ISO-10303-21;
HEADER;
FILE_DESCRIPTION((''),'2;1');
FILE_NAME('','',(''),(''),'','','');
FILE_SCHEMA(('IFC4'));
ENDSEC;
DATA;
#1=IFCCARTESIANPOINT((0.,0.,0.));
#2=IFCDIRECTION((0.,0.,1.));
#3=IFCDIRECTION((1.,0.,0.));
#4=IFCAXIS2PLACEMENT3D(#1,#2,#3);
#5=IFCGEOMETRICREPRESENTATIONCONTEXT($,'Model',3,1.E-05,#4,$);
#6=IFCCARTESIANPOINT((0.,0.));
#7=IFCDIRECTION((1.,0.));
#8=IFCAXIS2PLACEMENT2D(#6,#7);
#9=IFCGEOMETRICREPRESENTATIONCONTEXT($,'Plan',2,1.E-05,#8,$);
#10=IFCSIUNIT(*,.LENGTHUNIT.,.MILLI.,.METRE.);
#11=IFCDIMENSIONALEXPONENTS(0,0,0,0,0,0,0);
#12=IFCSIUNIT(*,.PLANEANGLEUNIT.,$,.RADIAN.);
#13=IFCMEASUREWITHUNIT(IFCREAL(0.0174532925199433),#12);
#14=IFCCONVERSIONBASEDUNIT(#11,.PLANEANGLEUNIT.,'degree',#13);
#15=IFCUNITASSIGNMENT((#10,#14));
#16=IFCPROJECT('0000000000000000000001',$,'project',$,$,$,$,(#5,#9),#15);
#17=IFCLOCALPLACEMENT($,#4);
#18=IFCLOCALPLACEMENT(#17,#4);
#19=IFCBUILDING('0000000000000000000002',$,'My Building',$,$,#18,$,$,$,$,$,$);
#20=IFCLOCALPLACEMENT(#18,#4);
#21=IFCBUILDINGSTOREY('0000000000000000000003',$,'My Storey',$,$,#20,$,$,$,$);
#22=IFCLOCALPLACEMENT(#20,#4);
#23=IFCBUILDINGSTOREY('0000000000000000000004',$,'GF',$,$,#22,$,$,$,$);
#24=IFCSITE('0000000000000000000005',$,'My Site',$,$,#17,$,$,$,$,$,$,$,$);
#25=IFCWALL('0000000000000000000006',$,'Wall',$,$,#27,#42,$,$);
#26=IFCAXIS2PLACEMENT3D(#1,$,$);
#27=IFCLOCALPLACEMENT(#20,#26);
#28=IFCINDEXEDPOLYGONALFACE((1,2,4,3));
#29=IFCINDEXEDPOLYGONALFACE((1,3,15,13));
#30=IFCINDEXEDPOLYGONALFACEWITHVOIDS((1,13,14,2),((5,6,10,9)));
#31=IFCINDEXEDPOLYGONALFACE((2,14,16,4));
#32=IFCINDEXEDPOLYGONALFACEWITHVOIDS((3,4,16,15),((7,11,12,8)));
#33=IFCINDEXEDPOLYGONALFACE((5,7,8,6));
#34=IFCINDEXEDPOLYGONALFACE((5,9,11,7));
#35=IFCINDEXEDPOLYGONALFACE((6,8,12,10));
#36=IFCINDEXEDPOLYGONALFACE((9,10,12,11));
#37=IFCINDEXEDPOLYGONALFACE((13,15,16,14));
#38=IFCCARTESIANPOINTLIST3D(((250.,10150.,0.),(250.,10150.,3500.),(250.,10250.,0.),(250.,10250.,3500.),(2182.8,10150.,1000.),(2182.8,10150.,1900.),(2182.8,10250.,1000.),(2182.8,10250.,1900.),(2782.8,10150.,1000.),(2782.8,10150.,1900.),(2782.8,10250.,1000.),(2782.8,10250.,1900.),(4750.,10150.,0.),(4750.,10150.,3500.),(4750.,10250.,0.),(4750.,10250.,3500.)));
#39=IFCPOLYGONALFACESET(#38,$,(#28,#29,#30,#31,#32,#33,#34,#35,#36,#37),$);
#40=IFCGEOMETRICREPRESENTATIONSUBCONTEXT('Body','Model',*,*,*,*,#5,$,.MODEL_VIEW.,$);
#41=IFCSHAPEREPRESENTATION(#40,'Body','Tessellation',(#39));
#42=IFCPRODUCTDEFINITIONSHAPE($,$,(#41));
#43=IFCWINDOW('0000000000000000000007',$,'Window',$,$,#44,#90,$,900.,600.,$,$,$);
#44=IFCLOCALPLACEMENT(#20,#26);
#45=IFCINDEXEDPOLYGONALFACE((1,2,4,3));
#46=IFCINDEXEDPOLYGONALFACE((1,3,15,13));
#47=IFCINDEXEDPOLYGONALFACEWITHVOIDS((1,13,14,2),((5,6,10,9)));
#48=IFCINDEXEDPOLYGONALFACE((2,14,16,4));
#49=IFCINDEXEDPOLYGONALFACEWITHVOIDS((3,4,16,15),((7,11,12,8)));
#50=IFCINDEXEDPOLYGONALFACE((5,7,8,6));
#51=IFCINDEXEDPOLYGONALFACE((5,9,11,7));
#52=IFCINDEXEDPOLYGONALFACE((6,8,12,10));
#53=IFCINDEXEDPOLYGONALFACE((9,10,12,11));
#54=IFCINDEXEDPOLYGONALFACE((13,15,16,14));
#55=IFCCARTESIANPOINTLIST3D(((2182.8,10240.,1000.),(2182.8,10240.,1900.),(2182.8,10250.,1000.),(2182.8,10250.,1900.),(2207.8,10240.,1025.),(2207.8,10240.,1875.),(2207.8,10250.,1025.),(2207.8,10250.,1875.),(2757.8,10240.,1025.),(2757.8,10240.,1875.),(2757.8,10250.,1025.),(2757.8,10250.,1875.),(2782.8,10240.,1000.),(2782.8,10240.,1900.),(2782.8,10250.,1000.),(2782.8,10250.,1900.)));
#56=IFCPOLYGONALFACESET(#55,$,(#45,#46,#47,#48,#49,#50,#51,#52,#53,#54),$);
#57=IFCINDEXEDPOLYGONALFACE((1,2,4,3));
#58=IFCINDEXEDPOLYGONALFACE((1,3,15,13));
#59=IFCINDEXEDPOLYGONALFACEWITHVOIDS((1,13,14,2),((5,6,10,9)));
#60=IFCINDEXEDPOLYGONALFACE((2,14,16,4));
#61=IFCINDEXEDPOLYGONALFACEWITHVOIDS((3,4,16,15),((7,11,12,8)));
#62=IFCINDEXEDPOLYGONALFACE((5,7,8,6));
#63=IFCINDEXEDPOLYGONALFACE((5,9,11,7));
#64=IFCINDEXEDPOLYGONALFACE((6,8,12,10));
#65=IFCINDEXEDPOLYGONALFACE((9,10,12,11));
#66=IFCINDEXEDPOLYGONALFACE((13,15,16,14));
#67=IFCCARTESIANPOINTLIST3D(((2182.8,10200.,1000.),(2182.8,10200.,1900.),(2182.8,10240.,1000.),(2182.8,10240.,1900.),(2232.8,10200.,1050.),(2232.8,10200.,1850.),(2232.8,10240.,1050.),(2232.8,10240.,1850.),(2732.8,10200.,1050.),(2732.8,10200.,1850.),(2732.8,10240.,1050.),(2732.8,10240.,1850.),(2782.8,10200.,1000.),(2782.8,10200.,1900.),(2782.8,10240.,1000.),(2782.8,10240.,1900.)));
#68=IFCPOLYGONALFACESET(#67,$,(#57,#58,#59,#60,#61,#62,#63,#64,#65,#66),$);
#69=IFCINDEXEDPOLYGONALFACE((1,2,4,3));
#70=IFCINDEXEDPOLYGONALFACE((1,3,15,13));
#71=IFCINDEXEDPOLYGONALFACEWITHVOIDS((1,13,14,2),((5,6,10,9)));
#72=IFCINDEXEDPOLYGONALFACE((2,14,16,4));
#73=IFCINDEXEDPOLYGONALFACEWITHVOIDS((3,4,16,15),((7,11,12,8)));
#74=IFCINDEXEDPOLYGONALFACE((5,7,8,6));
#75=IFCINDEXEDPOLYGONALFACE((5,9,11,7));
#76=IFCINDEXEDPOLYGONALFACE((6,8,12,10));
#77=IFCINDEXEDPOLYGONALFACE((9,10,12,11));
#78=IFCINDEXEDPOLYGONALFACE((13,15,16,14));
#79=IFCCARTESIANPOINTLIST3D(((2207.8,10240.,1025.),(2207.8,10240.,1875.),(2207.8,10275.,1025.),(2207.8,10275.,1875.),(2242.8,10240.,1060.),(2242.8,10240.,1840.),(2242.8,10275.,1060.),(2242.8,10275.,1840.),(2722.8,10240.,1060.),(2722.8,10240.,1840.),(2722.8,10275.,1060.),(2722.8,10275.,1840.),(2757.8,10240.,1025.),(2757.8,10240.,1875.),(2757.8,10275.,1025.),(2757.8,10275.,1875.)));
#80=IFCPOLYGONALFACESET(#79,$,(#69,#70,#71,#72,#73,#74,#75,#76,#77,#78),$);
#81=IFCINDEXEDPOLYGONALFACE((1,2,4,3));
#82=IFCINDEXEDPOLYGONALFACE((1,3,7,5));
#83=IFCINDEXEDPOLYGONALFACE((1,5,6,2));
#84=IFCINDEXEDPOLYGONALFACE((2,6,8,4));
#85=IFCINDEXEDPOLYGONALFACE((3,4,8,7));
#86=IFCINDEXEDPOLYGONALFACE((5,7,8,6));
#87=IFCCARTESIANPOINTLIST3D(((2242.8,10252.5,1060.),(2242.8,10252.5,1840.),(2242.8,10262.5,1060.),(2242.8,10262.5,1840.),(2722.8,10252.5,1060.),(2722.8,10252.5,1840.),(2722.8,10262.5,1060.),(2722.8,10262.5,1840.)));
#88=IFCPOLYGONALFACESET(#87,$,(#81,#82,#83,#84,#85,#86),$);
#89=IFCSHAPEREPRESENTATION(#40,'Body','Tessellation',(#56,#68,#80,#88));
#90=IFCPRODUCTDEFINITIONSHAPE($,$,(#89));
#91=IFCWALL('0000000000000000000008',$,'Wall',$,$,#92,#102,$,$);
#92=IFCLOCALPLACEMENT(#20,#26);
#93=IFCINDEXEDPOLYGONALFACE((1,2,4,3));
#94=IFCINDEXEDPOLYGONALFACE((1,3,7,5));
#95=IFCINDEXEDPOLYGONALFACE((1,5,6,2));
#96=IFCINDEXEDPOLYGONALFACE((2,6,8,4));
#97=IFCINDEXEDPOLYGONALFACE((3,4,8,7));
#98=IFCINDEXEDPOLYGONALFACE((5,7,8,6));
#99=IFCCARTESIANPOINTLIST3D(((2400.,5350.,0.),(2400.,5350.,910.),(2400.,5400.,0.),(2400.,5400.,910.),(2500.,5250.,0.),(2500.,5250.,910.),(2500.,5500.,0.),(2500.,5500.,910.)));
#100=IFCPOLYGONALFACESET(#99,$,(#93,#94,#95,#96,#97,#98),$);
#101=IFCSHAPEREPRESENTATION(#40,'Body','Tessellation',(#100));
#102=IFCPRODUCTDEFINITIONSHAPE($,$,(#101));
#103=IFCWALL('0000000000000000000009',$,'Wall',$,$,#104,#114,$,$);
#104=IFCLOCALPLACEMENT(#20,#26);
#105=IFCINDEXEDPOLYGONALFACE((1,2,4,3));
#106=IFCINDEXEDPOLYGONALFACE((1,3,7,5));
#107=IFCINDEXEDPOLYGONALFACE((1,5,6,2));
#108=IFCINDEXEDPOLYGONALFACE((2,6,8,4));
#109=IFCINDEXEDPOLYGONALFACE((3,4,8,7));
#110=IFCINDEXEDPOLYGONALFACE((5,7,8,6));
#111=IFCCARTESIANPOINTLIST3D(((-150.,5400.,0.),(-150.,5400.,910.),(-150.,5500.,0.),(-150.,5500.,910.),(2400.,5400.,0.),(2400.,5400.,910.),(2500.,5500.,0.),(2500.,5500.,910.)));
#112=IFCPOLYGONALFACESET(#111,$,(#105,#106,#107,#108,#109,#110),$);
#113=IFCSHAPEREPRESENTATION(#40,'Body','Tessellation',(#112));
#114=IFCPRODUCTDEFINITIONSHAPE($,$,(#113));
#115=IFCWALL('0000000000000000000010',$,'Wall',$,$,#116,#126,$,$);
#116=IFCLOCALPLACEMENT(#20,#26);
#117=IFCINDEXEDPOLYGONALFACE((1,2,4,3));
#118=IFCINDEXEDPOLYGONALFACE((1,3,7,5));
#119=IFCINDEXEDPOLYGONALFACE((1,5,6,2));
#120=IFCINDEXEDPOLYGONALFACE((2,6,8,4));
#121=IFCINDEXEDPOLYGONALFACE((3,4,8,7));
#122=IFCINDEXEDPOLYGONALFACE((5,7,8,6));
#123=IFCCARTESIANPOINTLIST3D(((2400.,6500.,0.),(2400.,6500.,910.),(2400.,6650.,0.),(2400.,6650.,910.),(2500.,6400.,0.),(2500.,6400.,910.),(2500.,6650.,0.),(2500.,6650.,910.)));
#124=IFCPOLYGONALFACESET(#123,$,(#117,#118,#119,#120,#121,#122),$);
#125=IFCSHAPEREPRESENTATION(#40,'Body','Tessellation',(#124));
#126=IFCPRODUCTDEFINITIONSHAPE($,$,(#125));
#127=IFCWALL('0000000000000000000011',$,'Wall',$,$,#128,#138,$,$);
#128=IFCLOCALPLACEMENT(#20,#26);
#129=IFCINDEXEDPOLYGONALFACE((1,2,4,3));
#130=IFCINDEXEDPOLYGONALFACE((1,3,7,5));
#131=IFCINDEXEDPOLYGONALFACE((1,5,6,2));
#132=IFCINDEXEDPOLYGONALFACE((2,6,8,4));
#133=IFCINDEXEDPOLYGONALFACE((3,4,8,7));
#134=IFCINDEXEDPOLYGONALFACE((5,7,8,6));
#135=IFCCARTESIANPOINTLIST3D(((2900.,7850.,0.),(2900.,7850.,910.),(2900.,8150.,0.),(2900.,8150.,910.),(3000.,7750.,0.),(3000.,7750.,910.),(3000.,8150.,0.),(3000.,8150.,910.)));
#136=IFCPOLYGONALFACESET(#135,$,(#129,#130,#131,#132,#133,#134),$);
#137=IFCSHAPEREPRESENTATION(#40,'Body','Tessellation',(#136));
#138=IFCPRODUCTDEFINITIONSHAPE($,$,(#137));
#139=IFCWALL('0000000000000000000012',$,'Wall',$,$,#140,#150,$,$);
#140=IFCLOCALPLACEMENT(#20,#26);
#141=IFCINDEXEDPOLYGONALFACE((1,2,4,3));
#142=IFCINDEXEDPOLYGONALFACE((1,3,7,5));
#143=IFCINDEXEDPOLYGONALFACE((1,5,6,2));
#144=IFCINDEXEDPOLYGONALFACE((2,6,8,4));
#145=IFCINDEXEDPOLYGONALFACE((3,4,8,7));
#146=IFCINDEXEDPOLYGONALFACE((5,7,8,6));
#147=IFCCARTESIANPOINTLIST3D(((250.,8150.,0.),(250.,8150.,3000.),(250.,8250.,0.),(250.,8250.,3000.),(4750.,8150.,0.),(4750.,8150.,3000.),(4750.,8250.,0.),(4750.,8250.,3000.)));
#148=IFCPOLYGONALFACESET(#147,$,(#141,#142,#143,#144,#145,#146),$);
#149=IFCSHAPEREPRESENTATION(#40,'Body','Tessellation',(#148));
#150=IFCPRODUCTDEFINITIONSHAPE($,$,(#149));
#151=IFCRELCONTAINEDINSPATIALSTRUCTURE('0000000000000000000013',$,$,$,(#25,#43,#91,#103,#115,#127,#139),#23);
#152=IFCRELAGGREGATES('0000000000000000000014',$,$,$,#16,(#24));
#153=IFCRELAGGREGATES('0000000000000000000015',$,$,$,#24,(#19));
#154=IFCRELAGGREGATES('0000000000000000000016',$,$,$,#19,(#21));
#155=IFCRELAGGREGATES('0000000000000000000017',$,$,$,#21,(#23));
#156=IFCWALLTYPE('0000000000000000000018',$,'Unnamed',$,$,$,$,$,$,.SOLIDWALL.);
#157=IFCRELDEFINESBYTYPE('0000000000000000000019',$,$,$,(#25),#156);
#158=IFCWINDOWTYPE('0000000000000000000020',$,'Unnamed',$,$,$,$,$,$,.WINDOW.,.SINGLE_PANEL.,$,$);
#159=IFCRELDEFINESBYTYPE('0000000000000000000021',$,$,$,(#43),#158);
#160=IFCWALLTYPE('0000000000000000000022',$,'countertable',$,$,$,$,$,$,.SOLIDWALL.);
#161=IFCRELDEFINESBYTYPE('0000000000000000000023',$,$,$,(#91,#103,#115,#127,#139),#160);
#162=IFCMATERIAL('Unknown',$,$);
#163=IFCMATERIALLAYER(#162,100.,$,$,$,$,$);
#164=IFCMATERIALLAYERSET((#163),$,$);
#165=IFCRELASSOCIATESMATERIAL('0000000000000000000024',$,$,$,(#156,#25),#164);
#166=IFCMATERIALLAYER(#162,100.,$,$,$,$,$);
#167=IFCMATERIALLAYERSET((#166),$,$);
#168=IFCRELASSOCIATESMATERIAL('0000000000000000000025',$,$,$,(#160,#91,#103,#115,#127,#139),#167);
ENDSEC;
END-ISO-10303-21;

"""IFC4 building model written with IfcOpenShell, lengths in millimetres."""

from ifc_helpers import new_model, entity, si_unit, converted_unit, frame, origin_with_axes, origin_2d_with_axis, place, context, subcontext, project, spatial, line, indexed_curve, outline, extrude, shape, source, transform, mapped, material, layer, layer_set, layer_usage, type_object, type_shapes, element, fill, save


model = new_model("IFC4")

# Units and contexts
model_context = context("Model", 3, precision=1e-05, world=origin_with_axes())
plan_context = context("Plan", 2, precision=1e-05, world=origin_2d_with_axis())
body_context_1 = subcontext(model_context, "Body", "Model", "MODEL_VIEW")
body_context_2 = subcontext(plan_context, "Body", "Plan", "PLAN_VIEW")
ifc_project = project(units=[si_unit("LENGTHUNIT", "METRE", prefix="MILLI"), converted_unit("PLANEANGLEUNIT", "degree", entity("IfcReal", 0.0174532925199433), si_unit("PLANEANGLEUNIT", "RADIAN"), dimensions=[0, 0, 0, 0, 0, 0, 0])], contexts=[model_context, plan_context])

# Site, building, storeys
site_placement = place(None, origin_with_axes())
site = spatial("IfcSite", under=ifc_project, at=site_placement, Name="My Site")
building_placement = place(site_placement, origin_with_axes())
building = spatial("IfcBuilding", under=site, at=building_placement, Name="My Building")
storey_1_placement = place(building_placement, origin_with_axes())
storey_1 = spatial("IfcBuildingStorey", under=building, at=storey_1_placement, Name="My Storey")
storey_2_placement = place(storey_1_placement, origin_with_axes())
storey_2 = spatial("IfcBuildingStorey", under=storey_1, at=storey_2_placement, Name="GF")

# Shared definitions
ifc_material = material(Name="Unknown")
ifc_layer_1 = layer(ifc_material, 100.0)
ifc_layer_set_1 = layer_set([ifc_layer_1])
wall_type_1 = type_object("IfcWallType", Name="Unnamed", PredefinedType="SOLIDWALL", material=ifc_layer_set_1)

# Shared definitions
shared_shape_1 = source(origin_with_axes(), body_context_1, "Body", "SweptSolid", [
    extrude(outline(indexed_curve([(0.0, 0.0), (600.0, 0.0), (600.0, 900.0), (0.0, 900.0)], segments=[line(1, 2, 3, 4, 1)])), frame((0.0, -600.0, 0.0), z_axis=(0.0, -1.0, 0.0), x_axis=(1.0, 0.0, 0.0)), (0.0, 0.0, -1.0), 1200.0),
])
window_type = type_object("IfcWindowType", Name="Unnamed", PartitioningType="SINGLE_PANEL", PredefinedType="WINDOW")
shared_shape_2 = source(origin_with_axes(), body_context_1, "Body", "SweptSolid", [
    extrude(outline(indexed_curve([(0.0, 0.0), (600.0, 0.0), (600.0, 900.0), (0.0, 900.0)], segments=[line(1, 2, 3, 4, 1)]), holes=[indexed_curve([(25.0, 25.0), (575.0, 25.0), (575.0, 875.0), (25.0, 875.0)], segments=[line(1, 2, 3, 4, 1)])]), frame((0.0, 90.0, 0.0), z_axis=(0.0, -1.0, 0.0), x_axis=(1.0, 0.0, 0.0)), (0.0, 0.0, -1.0), 10.0),
    extrude(outline(indexed_curve([(0.0, 0.0), (600.0, 0.0), (600.0, 900.0), (0.0, 900.0)], segments=[line(1, 2, 3, 4, 1)]), holes=[indexed_curve([(50.0, 50.0), (550.0, 50.0), (550.0, 850.0), (50.0, 850.0)], segments=[line(1, 2, 3, 4, 1)])]), frame((0.0, 50.0, 0.0), z_axis=(0.0, -1.0, 0.0), x_axis=(1.0, 0.0, 0.0)), (0.0, 0.0, -1.0), 40.0),
    extrude(outline(indexed_curve([(0.0, 0.0), (550.0, 0.0), (550.0, 850.0), (0.0, 850.0)], segments=[line(1, 2, 3, 4, 1)]), holes=[indexed_curve([(35.0, 35.0), (515.0, 35.0), (515.0, 815.0), (35.0, 815.0)], segments=[line(1, 2, 3, 4, 1)])]), frame((25.0, 90.0, 25.0), z_axis=(0.0, -1.0, 0.0), x_axis=(1.0, 0.0, 0.0)), (0.0, 0.0, -1.0), 35.0),
    extrude(outline(indexed_curve([(35.0, 35.0), (515.0, 35.0), (515.0, 815.0), (35.0, 815.0)], segments=[line(1, 2, 3, 4, 1)])), frame((25.0, 102.5, 25.0), z_axis=(0.0, -1.0, 0.0), x_axis=(1.0, 0.0, 0.0)), (0.0, 0.0, -1.0), 10.0),
])
shared_shape_3 = source(origin_with_axes(), body_context_2, "Body", "Curve2D", [
    entity("IfcIndexedPolyCurve", entity("IfcCartesianPointList2D", [[50.0, 50.0], [550.0, 50.0]])),
    entity("IfcIndexedPolyCurve", entity("IfcCartesianPointList2D", [[0.0, 100.0], [25.0, 100.0], [25.0, 90.0], [50.0, 90.0], [50.0, 50.0], [0.0, 50.0]]), [entity("IfcLineIndex", [1, 2, 3, 4, 5, 6, 1])]),
    entity("IfcIndexedPolyCurve", entity("IfcCartesianPointList2D", [[600.0, 100.0], [575.0, 100.0], [575.0, 90.0], [550.0, 90.0], [550.0, 50.0], [600.0, 50.0]]), [entity("IfcLineIndex", [1, 2, 3, 4, 5, 6, 1])]),
    entity("IfcIndexedPolyCurve", entity("IfcCartesianPointList2D", [[25.0, 90.0], [60.0, 90.0], [60.0, 125.0], [25.0, 125.0]]), [entity("IfcLineIndex", [1, 2, 3, 4, 1])]),
    entity("IfcIndexedPolyCurve", entity("IfcCartesianPointList2D", [[575.0, 90.0], [540.0, 90.0], [540.0, 125.0], [575.0, 125.0]]), [entity("IfcLineIndex", [1, 2, 3, 4, 1])]),
    entity("IfcIndexedPolyCurve", entity("IfcCartesianPointList2D", [[60.0, 90.0], [540.0, 90.0]])),
    entity("IfcIndexedPolyCurve", entity("IfcCartesianPointList2D", [[60.0, 125.0], [540.0, 125.0]])),
    entity("IfcIndexedPolyCurve", entity("IfcCartesianPointList2D", [[60.0, 107.5], [540.0, 107.5]])),
])
type_shapes(window_type, [shared_shape_2, shared_shape_3])

# Wall, opening, window
ifc_layer_usage_1 = layer_usage(ifc_layer_set_1, "AXIS2", "POSITIVE", 0.0)
wall_1_placement = place(storey_2_placement, frame((250.0, 10150.0, 0.0), z_axis=(0.0, 0.0, 1.0), x_axis=(1.0, 0.0, 0.0)))
wall_1 = element("IfcWall", 1, at=wall_1_placement, inside=storey_2, type_object=wall_type_1, material=ifc_layer_usage_1, Name="Wall", context=body_context_1, shape_type="SweptSolid", body=[
    extrude(outline(indexed_curve([(0.0, 0.0), (0.0, 100.0), (4500.0, 100.0), (4500.0, 0.0)], segments=[line(1, 2, 3, 4, 1)])), origin_with_axes(), (0.0, 0.0, 1.0), 3500.0),
])
opening_1_placement = place(wall_1_placement, frame((1932.8, 0.0, 1000.0), z_axis=(0.0, 0.0, 1.0), x_axis=(1.0, 0.0, 0.0)))
opening_1 = element("IfcOpeningElement", 2, at=opening_1_placement, cuts=wall_1, PredefinedType="OPENING", context=body_context_1, shape_type="MappedRepresentation", body=[
    mapped(shared_shape_1, transform((0.0, 0.0, 0.0), x_axis=(1.0, 0.0, 0.0), y_axis=(0.0, 1.0, 0.0), z_axis=(0.0, 0.0, 1.0), scale=1.0)),
])
window_1_placement = place(opening_1_placement, origin_with_axes())
window_1 = element("IfcWindow", 3, at=window_1_placement, inside=storey_2, type_object=window_type, Name="Window", OverallHeight=900.0, OverallWidth=600.0, shapes=[
    shape(body_context_1, "Body", "MappedRepresentation", [mapped(shared_shape_2, transform((0.0, 0.0, 0.0), x_axis=(1.0, 0.0, 0.0), y_axis=(0.0, 1.0, 0.0), z_axis=(0.0, 0.0, 1.0), scale=1.0))]),
    shape(body_context_2, "Body", "MappedRepresentation", [mapped(shared_shape_3, transform((0.0, 0.0, 0.0), x_axis=(1.0, 0.0, 0.0), y_axis=(0.0, 1.0, 0.0), z_axis=(0.0, 0.0, 1.0), scale=1.0))]),
])
fill(opening_1, window_1)

# Walls
ifc_layer_2 = layer(ifc_material, 100.0)
ifc_layer_set_2 = layer_set([ifc_layer_2])
ifc_layer_usage_2 = layer_usage(ifc_layer_set_2, "AXIS2", "POSITIVE", 0.0)
wall_type_2 = type_object("IfcWallType", Name="countertable", PredefinedType="SOLIDWALL", material=ifc_layer_set_2)
wall_2_placement = place(storey_2_placement, frame((2500.0, 5250.0, 0.0), z_axis=(0.0, 0.0, 1.0), x_axis=(0.0, 1.0, 0.0)))
element("IfcWall", 4, at=wall_2_placement, inside=storey_2, type_object=wall_type_2, material=ifc_layer_usage_2, Name="Wall", context=body_context_1, shape_type="SweptSolid", body=[
    extrude(outline(indexed_curve([(0.0, 0.0), (100.0, 100.0), (150.0, 100.0), (250.0, 0.0)], segments=[line(1, 2, 3, 4, 1)])), origin_with_axes(), (0.0, 0.0, 1.0), 910.0),
])
ifc_layer_usage_3 = layer_usage(ifc_layer_set_2, "AXIS2", "POSITIVE", 0.0)
wall_3_placement = place(storey_2_placement, frame((2500.0, 5500.0, 0.0), z_axis=(0.0, 0.0, 1.0), x_axis=(-1.0, 0.0, 0.0)))
element("IfcWall", 5, at=wall_3_placement, inside=storey_2, type_object=wall_type_2, material=ifc_layer_usage_3, Name="Wall", context=body_context_1, shape_type="SweptSolid", body=[
    extrude(outline(indexed_curve([(0.0, 0.0), (100.0, 100.0), (2650.0, 100.0), (2650.0, 0.0)], segments=[line(1, 2, 3, 4, 1)])), origin_with_axes(), (0.0, 0.0, 1.0), 910.0),
])
ifc_layer_usage_4 = layer_usage(ifc_layer_set_2, "AXIS2", "POSITIVE", 0.0)
wall_4_placement = place(storey_2_placement, frame((2500.0, 6400.0, 0.0), z_axis=(0.0, 0.0, 1.0), x_axis=(0.0, 1.0, 0.0)))
element("IfcWall", 6, at=wall_4_placement, inside=storey_2, type_object=wall_type_2, material=ifc_layer_usage_4, Name="Wall", context=body_context_1, shape_type="SweptSolid", body=[
    extrude(outline(indexed_curve([(0.0, 0.0), (100.0, 100.0), (250.0, 100.0), (250.0, 0.0)], segments=[line(1, 2, 3, 4, 1)])), origin_with_axes(), (0.0, 0.0, 1.0), 910.0),
])
ifc_layer_usage_5 = layer_usage(ifc_layer_set_2, "AXIS2", "POSITIVE", 0.0)
wall_5_placement = place(storey_2_placement, frame((3000.0, 7750.0, 0.0), z_axis=(0.0, 0.0, 1.0), x_axis=(0.0, 1.0, 0.0)))
element("IfcWall", 7, at=wall_5_placement, inside=storey_2, type_object=wall_type_2, material=ifc_layer_usage_5, Name="Wall", context=body_context_1, shape_type="SweptSolid", body=[
    extrude(outline(indexed_curve([(0.0, 0.0), (100.0, 100.0), (400.0, 100.0), (400.0, 0.0)], segments=[line(1, 2, 3, 4, 1)])), origin_with_axes(), (0.0, 0.0, 1.0), 910.0),
])
ifc_layer_usage_6 = layer_usage(ifc_layer_set_2, "AXIS2", "POSITIVE", 0.0)
wall_6_placement = place(storey_2_placement, frame((250.0, 8150.0, 0.0), z_axis=(0.0, 0.0, 1.0), x_axis=(1.0, 0.0, 0.0)))
element("IfcWall", 8, at=wall_6_placement, inside=storey_2, type_object=wall_type_2, material=ifc_layer_usage_6, Name="Wall", context=body_context_1, shape_type="SweptSolid", body=[
    extrude(outline(indexed_curve([(0.0, 0.0), (0.0, 100.0), (4500.0, 100.0), (4500.0, 0.0)], segments=[line(1, 2, 3, 4, 1)])), origin_with_axes(), (0.0, 0.0, 1.0), 3000.0),
])

save(model, "model.ifc")
